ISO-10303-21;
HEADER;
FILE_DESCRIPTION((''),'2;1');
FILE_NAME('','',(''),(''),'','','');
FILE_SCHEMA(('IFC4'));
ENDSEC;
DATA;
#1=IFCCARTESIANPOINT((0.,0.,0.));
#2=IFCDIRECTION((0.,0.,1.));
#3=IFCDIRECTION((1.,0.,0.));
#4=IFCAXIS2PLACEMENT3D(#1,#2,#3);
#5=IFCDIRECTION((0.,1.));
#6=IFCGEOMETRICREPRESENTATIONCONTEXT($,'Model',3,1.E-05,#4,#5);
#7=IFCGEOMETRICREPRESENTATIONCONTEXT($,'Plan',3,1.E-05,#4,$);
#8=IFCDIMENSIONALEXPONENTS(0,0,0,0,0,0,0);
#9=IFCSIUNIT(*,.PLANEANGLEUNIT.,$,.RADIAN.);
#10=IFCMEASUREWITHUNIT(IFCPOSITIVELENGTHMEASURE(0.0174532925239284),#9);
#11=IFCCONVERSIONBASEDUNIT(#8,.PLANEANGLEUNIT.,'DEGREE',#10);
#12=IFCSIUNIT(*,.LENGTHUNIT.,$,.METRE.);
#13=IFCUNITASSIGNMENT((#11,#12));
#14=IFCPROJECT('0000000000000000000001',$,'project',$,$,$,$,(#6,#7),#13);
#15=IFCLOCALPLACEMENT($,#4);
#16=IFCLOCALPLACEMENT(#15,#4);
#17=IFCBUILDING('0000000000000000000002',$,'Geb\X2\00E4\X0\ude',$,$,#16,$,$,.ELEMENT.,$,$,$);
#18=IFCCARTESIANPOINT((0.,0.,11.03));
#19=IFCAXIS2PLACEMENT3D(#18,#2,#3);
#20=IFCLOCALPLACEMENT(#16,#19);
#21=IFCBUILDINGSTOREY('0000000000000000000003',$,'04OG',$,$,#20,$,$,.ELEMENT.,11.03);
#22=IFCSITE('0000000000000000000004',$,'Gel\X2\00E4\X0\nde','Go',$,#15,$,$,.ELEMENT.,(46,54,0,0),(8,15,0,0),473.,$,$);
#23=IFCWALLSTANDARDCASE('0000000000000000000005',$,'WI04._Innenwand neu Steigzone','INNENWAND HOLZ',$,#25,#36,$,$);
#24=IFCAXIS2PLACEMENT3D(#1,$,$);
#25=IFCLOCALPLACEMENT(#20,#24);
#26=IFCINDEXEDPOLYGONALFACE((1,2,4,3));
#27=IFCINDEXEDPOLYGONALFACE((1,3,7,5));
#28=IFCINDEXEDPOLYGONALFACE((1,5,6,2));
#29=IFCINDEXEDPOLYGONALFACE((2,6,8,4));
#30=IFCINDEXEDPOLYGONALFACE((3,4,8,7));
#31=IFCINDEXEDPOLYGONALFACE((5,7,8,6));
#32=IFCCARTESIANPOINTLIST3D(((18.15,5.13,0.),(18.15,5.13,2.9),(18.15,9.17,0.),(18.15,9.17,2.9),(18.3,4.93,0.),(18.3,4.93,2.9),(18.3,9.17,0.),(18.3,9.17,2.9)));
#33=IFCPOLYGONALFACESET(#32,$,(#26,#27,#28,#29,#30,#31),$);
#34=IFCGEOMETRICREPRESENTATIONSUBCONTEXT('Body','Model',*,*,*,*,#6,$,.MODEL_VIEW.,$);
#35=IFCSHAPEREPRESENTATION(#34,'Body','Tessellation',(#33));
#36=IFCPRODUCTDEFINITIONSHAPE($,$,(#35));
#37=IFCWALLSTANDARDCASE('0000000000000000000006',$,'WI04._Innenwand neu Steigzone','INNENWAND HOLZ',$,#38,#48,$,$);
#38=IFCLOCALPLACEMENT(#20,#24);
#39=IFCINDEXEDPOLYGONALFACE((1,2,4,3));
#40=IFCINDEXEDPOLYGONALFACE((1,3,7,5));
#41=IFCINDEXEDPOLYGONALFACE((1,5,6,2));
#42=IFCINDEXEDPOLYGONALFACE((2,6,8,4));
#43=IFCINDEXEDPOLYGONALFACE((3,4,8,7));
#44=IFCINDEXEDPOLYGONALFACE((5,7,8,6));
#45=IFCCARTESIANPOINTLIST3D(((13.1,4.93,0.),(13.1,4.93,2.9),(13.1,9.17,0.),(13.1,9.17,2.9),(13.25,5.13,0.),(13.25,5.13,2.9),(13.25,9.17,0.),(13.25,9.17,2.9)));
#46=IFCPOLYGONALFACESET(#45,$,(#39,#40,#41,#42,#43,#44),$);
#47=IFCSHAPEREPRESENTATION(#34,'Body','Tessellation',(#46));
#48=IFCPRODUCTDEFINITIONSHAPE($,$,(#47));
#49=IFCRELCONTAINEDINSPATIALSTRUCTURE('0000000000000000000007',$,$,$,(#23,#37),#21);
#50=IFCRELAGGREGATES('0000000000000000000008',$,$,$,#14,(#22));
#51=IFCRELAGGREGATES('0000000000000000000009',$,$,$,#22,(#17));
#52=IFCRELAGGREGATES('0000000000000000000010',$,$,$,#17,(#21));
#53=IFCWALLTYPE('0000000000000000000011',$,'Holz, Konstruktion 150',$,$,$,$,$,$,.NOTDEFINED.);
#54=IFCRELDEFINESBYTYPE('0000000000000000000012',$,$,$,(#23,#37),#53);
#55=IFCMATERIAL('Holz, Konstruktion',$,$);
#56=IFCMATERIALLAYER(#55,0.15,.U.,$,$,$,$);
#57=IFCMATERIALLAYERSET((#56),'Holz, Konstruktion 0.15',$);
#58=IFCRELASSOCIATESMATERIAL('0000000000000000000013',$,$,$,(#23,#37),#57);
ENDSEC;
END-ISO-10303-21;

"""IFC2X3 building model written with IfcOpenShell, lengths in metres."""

from ifc_helpers import new_model, entity, si_unit, converted_unit, direction, frame, origin_with_axes, place, context, subcontext, project, spatial, polyline, outline, extrude, material, layer, layer_set, layer_usage, type_object, element, save


model = new_model("IFC2X3")

# Units and contexts
model_context = context("Model", 3, precision=1e-05, world=origin_with_axes(), true_north=direction((0.0, 1.0)))
plan_context = context("Plan", 3, precision=1e-05, world=origin_with_axes())
body_context = subcontext(model_context, "Body", "Model", "MODEL_VIEW")
ifc_project = project(units=[converted_unit("PLANEANGLEUNIT", "DEGREE", entity("IfcPositiveLengthMeasure", 0.0174532925239284), si_unit("PLANEANGLEUNIT", "RADIAN"), dimensions=[0, 0, 0, 0, 0, 0, 0]), si_unit("LENGTHUNIT", "METRE")], contexts=[model_context, plan_context])

# Site, building, storey
site_placement = place(None, origin_with_axes())
site = spatial("IfcSite", under=ifc_project, at=site_placement, Name="Gelände", Description="Go", CompositionType="ELEMENT", RefLatitude=(46, 54, 0, 0), RefLongitude=(8, 15, 0, 0), RefElevation=473.0)
building_placement = place(site_placement, origin_with_axes())
building = spatial("IfcBuilding", under=site, at=building_placement, Name="Gebäude", CompositionType="ELEMENT")
storey_placement = place(building_placement, frame((0.0, 0.0, 11.03), z_axis=(0.0, 0.0, 1.0), x_axis=(1.0, 0.0, 0.0)))
storey = spatial("IfcBuildingStorey", under=building, at=storey_placement, Name="04OG", CompositionType="ELEMENT", Elevation=11.03)

# Shared definitions
ifc_material_1 = material(Name="Holz, Konstruktion")

# Walls
ifc_layer_1 = layer(ifc_material_1, 0.15, ventilated="UNKNOWN")
ifc_layer_set_1 = layer_set([ifc_layer_1], Name="Holz, Konstruktion 0.15")
wall_type_1 = type_object("IfcWallType", Name="Holz, Konstruktion 150", PredefinedType="NOTDEFINED")
ifc_layer_usage_1 = layer_usage(ifc_layer_set_1, "AXIS2", "NEGATIVE", 0.0)
wall_1_placement = place(storey_placement, frame((18.3, 9.17, 0.0), z_axis=(0.0, 0.0, 1.0), x_axis=(0.0, -1.0, 0.0)))
element("IfcWallStandardCase", 1, at=wall_1_placement, inside=storey, type_object=wall_type_1, material=ifc_layer_usage_1, Name="WI04._Innenwand neu Steigzone", Description="INNENWAND HOLZ", context=body_context, shape_type="SweptSolid", body=[
    extrude(outline(polyline([(0.0, -0.15), (4.04, -0.15), (4.24, 0.0), (0.0, 0.0), (0.0, -0.15)])), origin_with_axes(), (0.0, 0.0, 1.0), 2.9),
])
ifc_layer_usage_2 = layer_usage(ifc_layer_set_1, "AXIS2", "POSITIVE", 0.0)
wall_2_placement = place(storey_placement, frame((13.1, 9.17, 0.0), z_axis=(0.0, 0.0, 1.0), x_axis=(0.0, -1.0, 0.0)))
element("IfcWallStandardCase", 2, at=wall_2_placement, inside=storey, type_object=wall_type_1, material=ifc_layer_usage_2, Name="WI04._Innenwand neu Steigzone", Description="INNENWAND HOLZ", context=body_context, shape_type="SweptSolid", body=[
    extrude(outline(polyline([(0.0, 0.0), (4.24, 0.0), (4.04, 0.15), (0.0, 0.15), (0.0, 0.0)])), origin_with_axes(), (0.0, 0.0, 1.0), 2.9),
])

save(model, "model.ifc")
